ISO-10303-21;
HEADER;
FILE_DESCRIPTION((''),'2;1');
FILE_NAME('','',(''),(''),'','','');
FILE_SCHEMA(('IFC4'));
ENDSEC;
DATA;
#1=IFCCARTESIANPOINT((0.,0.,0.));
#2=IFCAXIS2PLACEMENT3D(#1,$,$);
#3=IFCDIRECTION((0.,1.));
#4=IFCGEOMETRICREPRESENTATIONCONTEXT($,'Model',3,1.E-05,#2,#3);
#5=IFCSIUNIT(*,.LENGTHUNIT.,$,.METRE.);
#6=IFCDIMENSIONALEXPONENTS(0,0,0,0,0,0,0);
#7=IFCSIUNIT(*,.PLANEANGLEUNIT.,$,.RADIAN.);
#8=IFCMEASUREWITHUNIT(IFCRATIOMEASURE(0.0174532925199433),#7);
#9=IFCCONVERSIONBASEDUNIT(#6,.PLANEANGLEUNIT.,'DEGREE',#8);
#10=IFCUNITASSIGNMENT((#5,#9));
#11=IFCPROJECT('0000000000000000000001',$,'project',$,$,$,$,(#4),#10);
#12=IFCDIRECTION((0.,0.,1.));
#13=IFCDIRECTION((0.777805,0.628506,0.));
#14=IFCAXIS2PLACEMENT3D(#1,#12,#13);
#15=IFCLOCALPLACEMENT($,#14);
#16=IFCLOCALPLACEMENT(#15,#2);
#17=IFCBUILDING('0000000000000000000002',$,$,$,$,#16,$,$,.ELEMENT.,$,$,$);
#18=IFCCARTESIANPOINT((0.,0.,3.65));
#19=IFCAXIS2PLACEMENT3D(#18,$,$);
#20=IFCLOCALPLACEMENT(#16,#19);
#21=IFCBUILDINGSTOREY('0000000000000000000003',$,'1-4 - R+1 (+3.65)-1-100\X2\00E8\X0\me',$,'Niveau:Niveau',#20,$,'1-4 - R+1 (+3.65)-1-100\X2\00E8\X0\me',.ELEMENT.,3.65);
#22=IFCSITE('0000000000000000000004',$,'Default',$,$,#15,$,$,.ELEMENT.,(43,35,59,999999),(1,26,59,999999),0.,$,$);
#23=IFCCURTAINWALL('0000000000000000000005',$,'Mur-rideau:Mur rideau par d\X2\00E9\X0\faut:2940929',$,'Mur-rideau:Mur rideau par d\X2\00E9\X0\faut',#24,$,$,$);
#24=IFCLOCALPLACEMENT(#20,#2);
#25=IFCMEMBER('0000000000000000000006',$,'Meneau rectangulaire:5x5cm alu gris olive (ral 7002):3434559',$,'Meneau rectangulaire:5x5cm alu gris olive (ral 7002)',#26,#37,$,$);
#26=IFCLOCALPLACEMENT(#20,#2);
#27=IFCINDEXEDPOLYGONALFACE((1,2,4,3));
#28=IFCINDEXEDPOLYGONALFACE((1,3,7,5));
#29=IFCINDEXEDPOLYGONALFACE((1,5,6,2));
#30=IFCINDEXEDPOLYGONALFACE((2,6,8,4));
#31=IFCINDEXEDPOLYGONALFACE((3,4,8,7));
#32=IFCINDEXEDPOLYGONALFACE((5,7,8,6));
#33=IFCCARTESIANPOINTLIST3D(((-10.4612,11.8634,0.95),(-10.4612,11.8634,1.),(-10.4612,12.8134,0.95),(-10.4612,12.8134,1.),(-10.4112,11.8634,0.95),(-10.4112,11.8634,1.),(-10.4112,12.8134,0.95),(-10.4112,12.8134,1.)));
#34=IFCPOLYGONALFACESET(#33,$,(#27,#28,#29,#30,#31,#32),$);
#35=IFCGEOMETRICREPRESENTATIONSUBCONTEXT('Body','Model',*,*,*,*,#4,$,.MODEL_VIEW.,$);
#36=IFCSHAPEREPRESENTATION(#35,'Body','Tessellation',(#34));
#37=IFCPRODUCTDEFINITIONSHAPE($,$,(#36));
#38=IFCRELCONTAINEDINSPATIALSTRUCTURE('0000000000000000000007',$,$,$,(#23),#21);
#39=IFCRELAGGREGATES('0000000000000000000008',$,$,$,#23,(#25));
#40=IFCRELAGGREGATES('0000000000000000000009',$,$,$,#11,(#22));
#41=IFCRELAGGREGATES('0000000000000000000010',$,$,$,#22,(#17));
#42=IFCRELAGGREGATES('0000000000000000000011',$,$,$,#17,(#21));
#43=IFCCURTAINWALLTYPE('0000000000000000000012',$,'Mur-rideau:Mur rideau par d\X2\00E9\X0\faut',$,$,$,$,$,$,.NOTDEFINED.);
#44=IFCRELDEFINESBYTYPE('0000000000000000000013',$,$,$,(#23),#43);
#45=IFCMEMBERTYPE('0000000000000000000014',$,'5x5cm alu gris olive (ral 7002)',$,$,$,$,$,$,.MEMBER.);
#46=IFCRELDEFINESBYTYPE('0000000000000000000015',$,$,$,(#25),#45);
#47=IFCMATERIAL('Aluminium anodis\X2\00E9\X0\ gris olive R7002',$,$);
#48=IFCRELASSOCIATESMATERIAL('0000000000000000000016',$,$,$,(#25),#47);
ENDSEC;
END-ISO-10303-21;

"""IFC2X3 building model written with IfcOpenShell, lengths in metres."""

from ifc_helpers import new_model, entity, si_unit, converted_unit, direction, frame, origin, origin_2d_with_axis, place, context, subcontext, project, spatial, rectangle, extrude, source, transform, mapped, material, type_object, type_shapes, element, aggregate, save


model = new_model("IFC2X3")

# Units and contexts
model_context = context("Model", 3, precision=1e-05, world=origin(), true_north=direction((0.0, 1.0)))
body_context = subcontext(model_context, "Body", "Model", "MODEL_VIEW")
ifc_project = project(units=[si_unit("LENGTHUNIT", "METRE"), converted_unit("PLANEANGLEUNIT", "DEGREE", entity("IfcRatioMeasure", 0.0174532925199433), si_unit("PLANEANGLEUNIT", "RADIAN"), dimensions=[0, 0, 0, 0, 0, 0, 0])], contexts=[model_context])

# Site, building, storey
site_placement = place(None, frame((0.0, 0.0, 0.0), z_axis=(0.0, 0.0, 1.0), x_axis=(0.777805, 0.628506, 0.0)))
site = spatial("IfcSite", under=ifc_project, at=site_placement, Name="Default", CompositionType="ELEMENT", RefLatitude=(43, 35, 59, 999999), RefLongitude=(1, 26, 59, 999999), RefElevation=0.0)
building_placement = place(site_placement, origin())
building = spatial("IfcBuilding", under=site, at=building_placement, CompositionType="ELEMENT")
storey_placement = place(building_placement, frame((0.0, 0.0, 3.65)))
storey = spatial("IfcBuildingStorey", under=building, at=storey_placement, Name="1-4 - R+1 (+3.65)-1-100ème", ObjectType="Niveau:Niveau", LongName="1-4 - R+1 (+3.65)-1-100ème", CompositionType="ELEMENT", Elevation=3.65)

# Curtain wall, member
curtain_wall_type = type_object("IfcCurtainWallType", Name="Mur-rideau:Mur rideau par défaut", PredefinedType="NOTDEFINED")
curtain_wall_placement = place(storey_placement, frame((0.0, 0.0, -3.65)))
curtain_wall = element("IfcCurtainWall", 1, at=curtain_wall_placement, inside=storey, type_object=curtain_wall_type, Name="Mur-rideau:Mur rideau par défaut:2940929", ObjectType="Mur-rideau:Mur rideau par défaut")
ifc_material_1 = material(Name="Aluminium anodisé gris olive R7002")
member_type_1 = type_object("IfcMemberType", Name="5x5cm alu gris olive (ral 7002)", PredefinedType="MEMBER")
shared_shape_1 = source(origin(), body_context, "Body", "SweptSolid", [
    extrude(rectangle(XDim=0.05, YDim=0.05, at=origin_2d_with_axis()), frame((0.0, 0.0, -0.95), z_axis=(0.0, 0.0, 1.0), x_axis=(0.0, -1.0, 0.0)), (0.0, 0.0, 1.0), 0.95),
])
type_shapes(member_type_1, [shared_shape_1])
member_1_placement = place(storey_placement, frame((-10.4362, 11.8634, 0.975), z_axis=(0.0, -1.0, 0.0), x_axis=(0.0, 0.0, 1.0)))
member_1 = element("IfcMember", 2, at=member_1_placement, type_object=member_type_1, material=ifc_material_1, Name="Meneau rectangulaire:5x5cm alu gris olive (ral 7002):3434559", ObjectType="Meneau rectangulaire:5x5cm alu gris olive (ral 7002)", context=body_context, shape_type="MappedRepresentation", body=[
    mapped(shared_shape_1, transform((0.0, 0.0, 0.0), scale=1.0)),
])
aggregate(curtain_wall, [member_1])

save(model, "model.ifc")
